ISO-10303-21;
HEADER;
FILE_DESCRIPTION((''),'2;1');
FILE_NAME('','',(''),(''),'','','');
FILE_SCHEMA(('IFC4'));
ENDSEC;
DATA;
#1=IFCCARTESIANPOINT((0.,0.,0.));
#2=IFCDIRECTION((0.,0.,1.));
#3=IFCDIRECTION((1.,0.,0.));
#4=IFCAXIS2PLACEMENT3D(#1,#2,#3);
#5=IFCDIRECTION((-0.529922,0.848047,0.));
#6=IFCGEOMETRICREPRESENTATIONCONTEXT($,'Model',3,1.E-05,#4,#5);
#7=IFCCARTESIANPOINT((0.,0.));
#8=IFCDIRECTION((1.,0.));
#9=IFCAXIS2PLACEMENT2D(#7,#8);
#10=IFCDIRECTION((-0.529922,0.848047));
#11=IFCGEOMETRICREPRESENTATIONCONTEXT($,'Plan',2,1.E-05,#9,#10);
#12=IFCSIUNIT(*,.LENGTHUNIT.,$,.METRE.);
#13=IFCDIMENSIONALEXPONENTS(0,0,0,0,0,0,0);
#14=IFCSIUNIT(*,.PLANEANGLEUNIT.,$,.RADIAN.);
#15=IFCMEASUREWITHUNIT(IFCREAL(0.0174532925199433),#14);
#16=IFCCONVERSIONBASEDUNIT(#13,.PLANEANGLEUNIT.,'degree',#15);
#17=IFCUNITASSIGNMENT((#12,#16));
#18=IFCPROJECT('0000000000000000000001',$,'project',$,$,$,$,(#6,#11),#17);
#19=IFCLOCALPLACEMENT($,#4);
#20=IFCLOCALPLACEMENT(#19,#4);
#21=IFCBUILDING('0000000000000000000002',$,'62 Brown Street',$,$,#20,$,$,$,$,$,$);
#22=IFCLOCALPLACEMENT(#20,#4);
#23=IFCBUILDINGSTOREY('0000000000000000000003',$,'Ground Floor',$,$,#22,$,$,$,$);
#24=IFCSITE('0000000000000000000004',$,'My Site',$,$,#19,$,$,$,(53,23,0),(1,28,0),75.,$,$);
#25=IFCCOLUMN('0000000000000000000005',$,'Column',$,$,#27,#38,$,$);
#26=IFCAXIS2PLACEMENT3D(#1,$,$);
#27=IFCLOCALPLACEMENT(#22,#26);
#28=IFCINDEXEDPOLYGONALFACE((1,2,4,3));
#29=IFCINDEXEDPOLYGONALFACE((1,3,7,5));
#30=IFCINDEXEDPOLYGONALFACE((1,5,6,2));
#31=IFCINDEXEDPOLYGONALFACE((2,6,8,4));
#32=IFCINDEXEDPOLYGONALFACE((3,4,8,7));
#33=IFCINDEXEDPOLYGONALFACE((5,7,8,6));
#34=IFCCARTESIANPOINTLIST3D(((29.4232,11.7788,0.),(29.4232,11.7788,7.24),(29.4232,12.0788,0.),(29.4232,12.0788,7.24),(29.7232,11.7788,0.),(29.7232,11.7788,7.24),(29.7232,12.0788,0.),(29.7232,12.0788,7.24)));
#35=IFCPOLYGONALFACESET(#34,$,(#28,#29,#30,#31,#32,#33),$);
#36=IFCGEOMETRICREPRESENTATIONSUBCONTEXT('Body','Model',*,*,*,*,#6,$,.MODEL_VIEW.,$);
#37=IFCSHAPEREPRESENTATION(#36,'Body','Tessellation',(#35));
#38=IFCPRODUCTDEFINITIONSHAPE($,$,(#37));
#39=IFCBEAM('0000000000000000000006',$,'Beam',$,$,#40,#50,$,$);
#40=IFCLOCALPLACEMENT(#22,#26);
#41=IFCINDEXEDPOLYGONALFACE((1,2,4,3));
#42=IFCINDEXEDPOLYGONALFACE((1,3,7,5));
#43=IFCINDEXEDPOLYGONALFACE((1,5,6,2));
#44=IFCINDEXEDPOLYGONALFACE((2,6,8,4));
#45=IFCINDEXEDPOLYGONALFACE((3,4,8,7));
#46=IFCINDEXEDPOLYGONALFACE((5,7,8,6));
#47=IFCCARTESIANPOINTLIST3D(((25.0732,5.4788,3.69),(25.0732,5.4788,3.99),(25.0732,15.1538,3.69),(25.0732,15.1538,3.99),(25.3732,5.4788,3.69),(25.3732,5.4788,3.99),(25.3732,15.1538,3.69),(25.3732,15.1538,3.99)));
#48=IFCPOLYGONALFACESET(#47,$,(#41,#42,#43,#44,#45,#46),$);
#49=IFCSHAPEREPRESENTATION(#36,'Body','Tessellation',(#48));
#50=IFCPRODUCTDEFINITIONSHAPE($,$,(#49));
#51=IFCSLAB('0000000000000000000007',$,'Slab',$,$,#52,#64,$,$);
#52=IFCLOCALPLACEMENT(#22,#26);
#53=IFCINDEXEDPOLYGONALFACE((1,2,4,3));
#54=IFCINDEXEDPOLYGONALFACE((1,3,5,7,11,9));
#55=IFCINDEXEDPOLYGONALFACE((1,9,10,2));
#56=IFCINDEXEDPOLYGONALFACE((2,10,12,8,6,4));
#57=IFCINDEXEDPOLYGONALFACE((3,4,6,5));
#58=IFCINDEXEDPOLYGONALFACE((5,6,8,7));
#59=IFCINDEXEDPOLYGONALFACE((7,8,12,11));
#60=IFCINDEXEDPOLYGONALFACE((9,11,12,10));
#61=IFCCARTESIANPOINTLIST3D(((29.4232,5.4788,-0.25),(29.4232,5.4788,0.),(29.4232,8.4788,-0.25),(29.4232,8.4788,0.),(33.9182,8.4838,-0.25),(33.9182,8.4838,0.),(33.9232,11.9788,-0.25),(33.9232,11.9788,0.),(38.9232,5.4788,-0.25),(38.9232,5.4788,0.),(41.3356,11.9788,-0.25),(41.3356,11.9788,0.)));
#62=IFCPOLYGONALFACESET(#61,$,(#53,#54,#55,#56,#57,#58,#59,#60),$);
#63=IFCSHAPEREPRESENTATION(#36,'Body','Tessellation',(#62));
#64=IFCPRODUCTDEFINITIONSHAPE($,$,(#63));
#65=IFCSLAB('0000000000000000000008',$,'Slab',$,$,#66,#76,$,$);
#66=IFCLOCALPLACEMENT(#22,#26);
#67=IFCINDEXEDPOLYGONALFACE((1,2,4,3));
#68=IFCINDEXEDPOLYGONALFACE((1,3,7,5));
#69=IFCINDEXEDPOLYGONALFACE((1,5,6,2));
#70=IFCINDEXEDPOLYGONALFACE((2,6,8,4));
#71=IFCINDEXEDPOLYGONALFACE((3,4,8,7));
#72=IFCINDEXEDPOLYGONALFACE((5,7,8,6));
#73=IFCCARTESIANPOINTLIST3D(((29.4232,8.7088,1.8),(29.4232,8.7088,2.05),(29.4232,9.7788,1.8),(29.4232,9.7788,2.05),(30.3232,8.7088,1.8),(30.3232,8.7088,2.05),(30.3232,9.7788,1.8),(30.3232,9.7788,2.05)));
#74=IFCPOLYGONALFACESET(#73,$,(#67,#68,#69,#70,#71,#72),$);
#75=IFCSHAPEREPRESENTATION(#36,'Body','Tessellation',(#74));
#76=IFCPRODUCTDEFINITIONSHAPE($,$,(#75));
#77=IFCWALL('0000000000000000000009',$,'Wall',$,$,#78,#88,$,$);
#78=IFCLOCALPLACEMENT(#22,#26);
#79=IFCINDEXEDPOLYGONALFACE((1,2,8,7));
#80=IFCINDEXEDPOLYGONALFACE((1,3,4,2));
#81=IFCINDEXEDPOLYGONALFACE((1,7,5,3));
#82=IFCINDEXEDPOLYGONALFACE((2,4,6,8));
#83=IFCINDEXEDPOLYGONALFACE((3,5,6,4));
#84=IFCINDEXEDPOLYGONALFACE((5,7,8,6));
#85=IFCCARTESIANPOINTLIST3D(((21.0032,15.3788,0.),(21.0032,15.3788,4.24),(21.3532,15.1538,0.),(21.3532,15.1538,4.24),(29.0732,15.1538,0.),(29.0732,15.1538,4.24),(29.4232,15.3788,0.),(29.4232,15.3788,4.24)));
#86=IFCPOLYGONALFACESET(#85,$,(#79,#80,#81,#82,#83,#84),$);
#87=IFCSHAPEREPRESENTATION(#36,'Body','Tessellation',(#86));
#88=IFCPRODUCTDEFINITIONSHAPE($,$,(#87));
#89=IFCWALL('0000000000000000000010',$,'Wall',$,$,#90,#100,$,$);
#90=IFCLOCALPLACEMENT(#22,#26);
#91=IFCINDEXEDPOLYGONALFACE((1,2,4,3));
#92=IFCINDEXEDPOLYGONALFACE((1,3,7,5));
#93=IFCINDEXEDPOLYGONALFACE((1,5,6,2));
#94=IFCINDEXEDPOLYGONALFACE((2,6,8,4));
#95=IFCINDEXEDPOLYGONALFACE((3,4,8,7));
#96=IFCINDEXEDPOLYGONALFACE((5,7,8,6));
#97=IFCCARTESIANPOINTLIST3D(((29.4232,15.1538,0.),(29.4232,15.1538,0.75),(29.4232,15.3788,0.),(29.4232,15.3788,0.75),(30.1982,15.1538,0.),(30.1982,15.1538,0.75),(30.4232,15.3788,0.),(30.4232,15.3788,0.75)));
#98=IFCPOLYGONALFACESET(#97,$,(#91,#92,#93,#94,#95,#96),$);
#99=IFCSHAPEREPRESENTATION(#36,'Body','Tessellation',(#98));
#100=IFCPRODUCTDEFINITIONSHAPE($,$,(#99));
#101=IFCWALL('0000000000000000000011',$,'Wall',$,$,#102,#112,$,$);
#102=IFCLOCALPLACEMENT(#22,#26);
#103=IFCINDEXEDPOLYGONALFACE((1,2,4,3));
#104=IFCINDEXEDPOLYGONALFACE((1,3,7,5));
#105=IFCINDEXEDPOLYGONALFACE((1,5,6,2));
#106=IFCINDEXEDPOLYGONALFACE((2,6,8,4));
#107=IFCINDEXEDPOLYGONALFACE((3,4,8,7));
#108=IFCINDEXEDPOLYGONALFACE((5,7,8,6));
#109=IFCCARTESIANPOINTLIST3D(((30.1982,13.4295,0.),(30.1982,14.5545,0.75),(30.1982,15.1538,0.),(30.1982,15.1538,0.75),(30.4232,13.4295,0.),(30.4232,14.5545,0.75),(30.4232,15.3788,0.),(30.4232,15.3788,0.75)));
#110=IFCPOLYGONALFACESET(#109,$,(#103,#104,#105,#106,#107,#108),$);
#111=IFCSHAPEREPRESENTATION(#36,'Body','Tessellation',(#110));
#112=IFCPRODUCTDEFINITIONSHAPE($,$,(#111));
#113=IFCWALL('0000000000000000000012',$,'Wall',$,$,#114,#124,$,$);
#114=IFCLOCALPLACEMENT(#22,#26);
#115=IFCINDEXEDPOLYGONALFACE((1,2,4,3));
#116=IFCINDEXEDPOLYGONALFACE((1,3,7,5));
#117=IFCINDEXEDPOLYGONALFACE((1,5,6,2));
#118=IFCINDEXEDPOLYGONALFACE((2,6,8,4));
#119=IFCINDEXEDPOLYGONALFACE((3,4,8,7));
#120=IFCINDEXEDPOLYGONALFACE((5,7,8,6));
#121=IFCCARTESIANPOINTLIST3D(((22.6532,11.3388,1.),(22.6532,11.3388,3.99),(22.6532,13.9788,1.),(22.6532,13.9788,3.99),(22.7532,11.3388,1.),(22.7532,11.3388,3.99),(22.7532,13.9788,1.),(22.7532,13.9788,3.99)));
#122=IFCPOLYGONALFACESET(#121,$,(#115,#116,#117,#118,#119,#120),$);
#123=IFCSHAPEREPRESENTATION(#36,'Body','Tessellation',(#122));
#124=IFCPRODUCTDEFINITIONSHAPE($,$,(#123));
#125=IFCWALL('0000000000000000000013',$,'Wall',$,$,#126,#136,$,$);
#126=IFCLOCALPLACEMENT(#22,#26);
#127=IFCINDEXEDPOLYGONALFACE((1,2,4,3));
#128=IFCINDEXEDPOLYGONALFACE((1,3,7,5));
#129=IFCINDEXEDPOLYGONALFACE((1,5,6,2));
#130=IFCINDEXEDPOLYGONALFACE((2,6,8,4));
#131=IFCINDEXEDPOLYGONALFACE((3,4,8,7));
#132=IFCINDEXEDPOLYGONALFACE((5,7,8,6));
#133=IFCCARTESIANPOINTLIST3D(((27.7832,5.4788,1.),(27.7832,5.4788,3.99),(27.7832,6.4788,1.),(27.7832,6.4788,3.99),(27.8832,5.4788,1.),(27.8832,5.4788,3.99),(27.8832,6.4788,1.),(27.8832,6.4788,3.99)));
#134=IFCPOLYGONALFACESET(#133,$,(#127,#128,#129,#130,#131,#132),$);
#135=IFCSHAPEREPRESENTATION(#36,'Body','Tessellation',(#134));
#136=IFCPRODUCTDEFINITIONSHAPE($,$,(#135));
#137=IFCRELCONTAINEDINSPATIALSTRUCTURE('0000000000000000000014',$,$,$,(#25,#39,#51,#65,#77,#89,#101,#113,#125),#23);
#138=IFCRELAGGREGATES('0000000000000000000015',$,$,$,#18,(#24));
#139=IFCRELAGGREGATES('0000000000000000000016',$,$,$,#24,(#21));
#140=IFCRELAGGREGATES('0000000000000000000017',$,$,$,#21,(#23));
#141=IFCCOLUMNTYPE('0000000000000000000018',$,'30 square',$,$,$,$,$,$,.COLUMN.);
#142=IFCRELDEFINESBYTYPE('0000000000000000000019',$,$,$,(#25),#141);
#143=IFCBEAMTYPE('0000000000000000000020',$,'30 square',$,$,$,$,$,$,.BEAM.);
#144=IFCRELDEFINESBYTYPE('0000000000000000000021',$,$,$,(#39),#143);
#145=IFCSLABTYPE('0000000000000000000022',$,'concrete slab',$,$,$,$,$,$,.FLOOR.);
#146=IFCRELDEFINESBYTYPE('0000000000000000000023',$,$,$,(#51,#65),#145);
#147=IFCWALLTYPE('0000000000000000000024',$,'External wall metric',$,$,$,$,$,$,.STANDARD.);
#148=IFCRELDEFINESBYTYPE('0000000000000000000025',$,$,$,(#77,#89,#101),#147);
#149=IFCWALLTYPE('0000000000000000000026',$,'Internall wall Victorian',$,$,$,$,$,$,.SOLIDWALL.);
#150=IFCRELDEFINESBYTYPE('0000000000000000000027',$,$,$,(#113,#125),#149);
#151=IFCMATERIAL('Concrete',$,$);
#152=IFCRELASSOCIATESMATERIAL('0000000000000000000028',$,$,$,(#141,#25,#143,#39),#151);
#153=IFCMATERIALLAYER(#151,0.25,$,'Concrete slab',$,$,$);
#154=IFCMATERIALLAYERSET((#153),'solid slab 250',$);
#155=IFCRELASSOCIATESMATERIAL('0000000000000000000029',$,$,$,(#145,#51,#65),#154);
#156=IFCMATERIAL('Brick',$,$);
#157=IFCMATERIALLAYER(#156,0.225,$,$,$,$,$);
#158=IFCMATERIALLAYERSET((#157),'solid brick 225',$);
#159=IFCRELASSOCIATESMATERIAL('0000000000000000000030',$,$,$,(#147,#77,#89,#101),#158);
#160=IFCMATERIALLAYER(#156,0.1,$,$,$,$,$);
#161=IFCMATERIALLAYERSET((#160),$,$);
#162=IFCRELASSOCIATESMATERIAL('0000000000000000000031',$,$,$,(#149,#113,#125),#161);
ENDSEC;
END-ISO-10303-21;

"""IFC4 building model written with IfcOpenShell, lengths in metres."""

from ifc_helpers import new_model, entity, si_unit, converted_unit, direction, frame, origin_with_axes, origin_2d_with_axis, place, context, subcontext, project, spatial, line, indexed_curve, rectangle, outline, extrude, clip, halfspace, material, layer, layer_set, layer_usage, material_profile, profile_set, profile_usage, type_object, element, save


model = new_model("IFC4")

# Units and contexts
model_context = context("Model", 3, precision=1e-05, world=origin_with_axes(), true_north=direction((-0.529922, 0.848047, 0.0)))
plan_context = context("Plan", 2, precision=1e-05, world=origin_2d_with_axis(), true_north=direction((-0.529922, 0.848047)))
body_context = subcontext(model_context, "Body", "Model", "MODEL_VIEW")
ifc_project = project(units=[si_unit("LENGTHUNIT", "METRE"), converted_unit("PLANEANGLEUNIT", "degree", entity("IfcReal", 0.0174532925199433), si_unit("PLANEANGLEUNIT", "RADIAN"), dimensions=[0, 0, 0, 0, 0, 0, 0])], contexts=[model_context, plan_context])

# Site, building, storey
site_placement = place(None, origin_with_axes())
site = spatial("IfcSite", under=ifc_project, at=site_placement, Name="My Site", RefLatitude=(53, 23, 0), RefLongitude=(1, 28, 0), RefElevation=75.0)
building_placement = place(site_placement, origin_with_axes())
building = spatial("IfcBuilding", under=site, at=building_placement, Name="62 Brown Street")
storey_placement = place(building_placement, origin_with_axes())
storey = spatial("IfcBuildingStorey", under=building, at=storey_placement, Name="Ground Floor")

# Column
ifc_material_1 = material(Name="Concrete")
ifc_material_profile_1 = material_profile(ifc_material_1, rectangle(XDim=0.3, YDim=0.3))
ifc_profile_set_1 = profile_set([ifc_material_profile_1])
ifc_profile_usage_1 = profile_usage(ifc_profile_set_1, cardinal=5)
column_type = type_object("IfcColumnType", Name="30 square", PredefinedType="COLUMN", material=ifc_profile_set_1)
column_1_placement = place(storey_placement, frame((29.5732, 11.9288, 0.0), z_axis=(0.0, 0.0, 1.0), x_axis=(1.0, 0.0, 0.0)))
element("IfcColumn", 1, at=column_1_placement, inside=storey, type_object=column_type, material=ifc_profile_usage_1, Name="Column", context=body_context, shape_type="SweptSolid", body=[
    extrude(rectangle(XDim=0.3, YDim=0.3), origin_with_axes(), (0.0, 0.0, 1.0), 7.24),
])

# Beam
ifc_material_profile_2 = material_profile(ifc_material_1, rectangle(XDim=0.3, YDim=0.3))
ifc_profile_set_2 = profile_set([ifc_material_profile_2])
ifc_profile_usage_2 = profile_usage(ifc_profile_set_2, cardinal=5)
beam_type = type_object("IfcBeamType", Name="30 square", PredefinedType="BEAM", material=ifc_profile_set_2)
beam_placement = place(storey_placement, frame((25.2232, 5.4788, 3.84), z_axis=(0.0, 1.0, 0.0), x_axis=(-1.0, 0.0, 0.0)))
element("IfcBeam", 2, at=beam_placement, inside=storey, type_object=beam_type, material=ifc_profile_usage_2, Name="Beam", context=body_context, shape_type="SweptSolid", body=[
    extrude(rectangle(XDim=0.3, YDim=0.3), origin_with_axes(), (0.0, 0.0, 1.0), 9.675),
])

# Slabs
ifc_layer_1 = layer(ifc_material_1, 0.25, Name="Concrete slab")
ifc_layer_set_1 = layer_set([ifc_layer_1], Name="solid slab 250")
ifc_layer_usage_1 = layer_usage(ifc_layer_set_1, "AXIS3", "POSITIVE", 0.0)
slab_type_1 = type_object("IfcSlabType", Name="concrete slab", PredefinedType="FLOOR", material=ifc_layer_set_1)
slab_1_placement = place(storey_placement, frame((29.4232, 5.4788, -0.25), z_axis=(0.0, 0.0, 1.0), x_axis=(1.0, 0.0, 0.0)))
element("IfcSlab", 3, at=slab_1_placement, inside=storey, type_object=slab_type_1, material=ifc_layer_usage_1, Name="Slab", context=body_context, shape_type="SweptSolid", body=[
    extrude(outline(indexed_curve([(0.0, 0.0), (9.5, 0.0), (11.9124, 6.5), (0.0, 3.0), (4.5, 6.5), (4.495, 3.005)], segments=[line(1, 2), line(2, 3), line(3, 5), line(5, 6), line(6, 4), line(4, 1)], self_intersect=False)), None, (0.0, 0.0, 1.0), 0.25),
])
ifc_layer_usage_2 = layer_usage(ifc_layer_set_1, "AXIS3", "POSITIVE", 0.0)
slab_2_placement = place(storey_placement, frame((29.4232, 8.7088, 1.8), z_axis=(0.0, 0.0, 1.0), x_axis=(1.0, 0.0, 0.0)))
element("IfcSlab", 4, at=slab_2_placement, inside=storey, type_object=slab_type_1, material=ifc_layer_usage_2, Name="Slab", context=body_context, shape_type="SweptSolid", body=[
    extrude(outline(indexed_curve([(0.9, 1.07), (0.9, 0.0), (0.0, 0.0), (0.0, 1.07)], segments=[line(3, 2), line(2, 1), line(1, 4), line(4, 3)], self_intersect=False)), None, (0.0, 0.0, 1.0), 0.25),
])

# Walls
ifc_material_2 = material(Name="Brick")
ifc_layer_2 = layer(ifc_material_2, 0.225)
ifc_layer_set_2 = layer_set([ifc_layer_2], Name="solid brick 225")
wall_type_1 = type_object("IfcWallType", Name="External wall metric", PredefinedType="STANDARD", material=ifc_layer_set_2)
ifc_layer_usage_3 = layer_usage(ifc_layer_set_2, "AXIS2", "POSITIVE", 0.0)
wall_1_placement = place(storey_placement, frame((29.4232, 15.3788, 0.0), z_axis=(0.0, 0.0, 1.0), x_axis=(-1.0, 0.0, 0.0)))
element("IfcWall", 5, at=wall_1_placement, inside=storey, type_object=wall_type_1, material=ifc_layer_usage_3, Name="Wall", context=body_context, shape_type="Clipping", body=[
    clip(clip(extrude(outline(indexed_curve([(0.0, 0.0), (0.0, 0.225), (8.42, 0.225), (8.42, 0.0), (0.0, 0.0)], self_intersect=False)), origin_with_axes(), (0.0, 0.0, 1.0), 4.24), halfspace(frame((8.42, 0.0, 0.0), z_axis=(0.540756, 0.841179, 0.0), x_axis=(-0.841179, 0.540756, 0.0)), False)), halfspace(frame((0.0, 0.0, 0.0), z_axis=(-0.540758, 0.841178, 0.0), x_axis=(0.841178, 0.540758, 0.0)), False)),
])
ifc_layer_usage_4 = layer_usage(ifc_layer_set_2, "AXIS2", "POSITIVE", 0.0)
wall_2_placement = place(storey_placement, frame((30.4232, 15.3788, 0.0), z_axis=(0.0, 0.0, 1.0), x_axis=(-1.0, 0.0, 0.0)))
element("IfcWall", 6, at=wall_2_placement, inside=storey, type_object=wall_type_1, material=ifc_layer_usage_4, Name="Wall", context=body_context, shape_type="Clipping", body=[
    clip(extrude(outline(indexed_curve([(0.0, 0.0), (0.0, 0.225), (1.0, 0.225), (1.0, 0.0), (0.0, 0.0)], self_intersect=False)), origin_with_axes(), (0.0, 0.0, 1.0), 0.75), halfspace(frame((0.0, 0.0, 0.0), z_axis=(-0.707107, 0.707107, 0.0), x_axis=(0.707107, 0.707107, 0.0)), False)),
])
ifc_layer_usage_5 = layer_usage(ifc_layer_set_2, "AXIS2", "POSITIVE", 0.0)
wall_3_placement = place(storey_placement, frame((30.4232, 13.4295, 0.0), z_axis=(0.0, 0.0, 1.0), x_axis=(0.0, 1.0, 0.0)))
element("IfcWall", 7, at=wall_3_placement, inside=storey, type_object=wall_type_1, material=ifc_layer_usage_5, Name="Wall", context=body_context, shape_type="Clipping", body=[
    clip(clip(extrude(outline(indexed_curve([(0.0, 0.0), (0.0, 0.225), (1.9493, 0.225), (1.9493, 0.0), (0.0, 0.0)], self_intersect=False)), origin_with_axes(), (0.0, 0.0, 1.0), 0.75), halfspace(frame((0.416, 0.5, 0.2774), z_axis=(-0.5547, 0.0, 0.83205), x_axis=(0.0, -1.0, 0.0)), False)), halfspace(frame((1.9493, 0.0, 0.0), z_axis=(0.707107, 0.707107, 0.0), x_axis=(0.707107, -0.707107, 0.0)), False)),
])
ifc_layer_3 = layer(ifc_material_2, 0.1)
ifc_layer_set_3 = layer_set([ifc_layer_3])
ifc_layer_usage_6 = layer_usage(ifc_layer_set_3, "AXIS2", "POSITIVE", 0.0)
wall_type_2 = type_object("IfcWallType", Name="Internall wall Victorian", PredefinedType="SOLIDWALL", material=ifc_layer_set_3)
wall_4_placement = place(storey_placement, frame((22.7532, 11.3388, 1.0), z_axis=(0.0, 0.0, 1.0), x_axis=(0.0, 1.0, 0.0)))
element("IfcWall", 8, at=wall_4_placement, inside=storey, type_object=wall_type_2, material=ifc_layer_usage_6, Name="Wall", context=body_context, shape_type="SweptSolid", body=[
    extrude(outline(indexed_curve([(0.0, 0.0), (0.0, 0.1), (2.64, 0.1), (2.64, 0.0), (0.0, 0.0)], self_intersect=False)), origin_with_axes(), (0.0, 0.0, 1.0), 2.99),
])
ifc_layer_usage_7 = layer_usage(ifc_layer_set_3, "AXIS2", "POSITIVE", 0.0)
wall_5_placement = place(storey_placement, frame((27.8832, 5.4788, 1.0), z_axis=(0.0, 0.0, 1.0), x_axis=(0.0, 1.0, 0.0)))
element("IfcWall", 9, at=wall_5_placement, inside=storey, type_object=wall_type_2, material=ifc_layer_usage_7, Name="Wall", context=body_context, shape_type="SweptSolid", body=[
    extrude(outline(indexed_curve([(0.0, 0.0), (0.0, 0.1), (1.0, 0.1), (1.0, 0.0), (0.0, 0.0)], self_intersect=False)), origin_with_axes(), (0.0, 0.0, 1.0), 2.99),
])

save(model, "model.ifc")
